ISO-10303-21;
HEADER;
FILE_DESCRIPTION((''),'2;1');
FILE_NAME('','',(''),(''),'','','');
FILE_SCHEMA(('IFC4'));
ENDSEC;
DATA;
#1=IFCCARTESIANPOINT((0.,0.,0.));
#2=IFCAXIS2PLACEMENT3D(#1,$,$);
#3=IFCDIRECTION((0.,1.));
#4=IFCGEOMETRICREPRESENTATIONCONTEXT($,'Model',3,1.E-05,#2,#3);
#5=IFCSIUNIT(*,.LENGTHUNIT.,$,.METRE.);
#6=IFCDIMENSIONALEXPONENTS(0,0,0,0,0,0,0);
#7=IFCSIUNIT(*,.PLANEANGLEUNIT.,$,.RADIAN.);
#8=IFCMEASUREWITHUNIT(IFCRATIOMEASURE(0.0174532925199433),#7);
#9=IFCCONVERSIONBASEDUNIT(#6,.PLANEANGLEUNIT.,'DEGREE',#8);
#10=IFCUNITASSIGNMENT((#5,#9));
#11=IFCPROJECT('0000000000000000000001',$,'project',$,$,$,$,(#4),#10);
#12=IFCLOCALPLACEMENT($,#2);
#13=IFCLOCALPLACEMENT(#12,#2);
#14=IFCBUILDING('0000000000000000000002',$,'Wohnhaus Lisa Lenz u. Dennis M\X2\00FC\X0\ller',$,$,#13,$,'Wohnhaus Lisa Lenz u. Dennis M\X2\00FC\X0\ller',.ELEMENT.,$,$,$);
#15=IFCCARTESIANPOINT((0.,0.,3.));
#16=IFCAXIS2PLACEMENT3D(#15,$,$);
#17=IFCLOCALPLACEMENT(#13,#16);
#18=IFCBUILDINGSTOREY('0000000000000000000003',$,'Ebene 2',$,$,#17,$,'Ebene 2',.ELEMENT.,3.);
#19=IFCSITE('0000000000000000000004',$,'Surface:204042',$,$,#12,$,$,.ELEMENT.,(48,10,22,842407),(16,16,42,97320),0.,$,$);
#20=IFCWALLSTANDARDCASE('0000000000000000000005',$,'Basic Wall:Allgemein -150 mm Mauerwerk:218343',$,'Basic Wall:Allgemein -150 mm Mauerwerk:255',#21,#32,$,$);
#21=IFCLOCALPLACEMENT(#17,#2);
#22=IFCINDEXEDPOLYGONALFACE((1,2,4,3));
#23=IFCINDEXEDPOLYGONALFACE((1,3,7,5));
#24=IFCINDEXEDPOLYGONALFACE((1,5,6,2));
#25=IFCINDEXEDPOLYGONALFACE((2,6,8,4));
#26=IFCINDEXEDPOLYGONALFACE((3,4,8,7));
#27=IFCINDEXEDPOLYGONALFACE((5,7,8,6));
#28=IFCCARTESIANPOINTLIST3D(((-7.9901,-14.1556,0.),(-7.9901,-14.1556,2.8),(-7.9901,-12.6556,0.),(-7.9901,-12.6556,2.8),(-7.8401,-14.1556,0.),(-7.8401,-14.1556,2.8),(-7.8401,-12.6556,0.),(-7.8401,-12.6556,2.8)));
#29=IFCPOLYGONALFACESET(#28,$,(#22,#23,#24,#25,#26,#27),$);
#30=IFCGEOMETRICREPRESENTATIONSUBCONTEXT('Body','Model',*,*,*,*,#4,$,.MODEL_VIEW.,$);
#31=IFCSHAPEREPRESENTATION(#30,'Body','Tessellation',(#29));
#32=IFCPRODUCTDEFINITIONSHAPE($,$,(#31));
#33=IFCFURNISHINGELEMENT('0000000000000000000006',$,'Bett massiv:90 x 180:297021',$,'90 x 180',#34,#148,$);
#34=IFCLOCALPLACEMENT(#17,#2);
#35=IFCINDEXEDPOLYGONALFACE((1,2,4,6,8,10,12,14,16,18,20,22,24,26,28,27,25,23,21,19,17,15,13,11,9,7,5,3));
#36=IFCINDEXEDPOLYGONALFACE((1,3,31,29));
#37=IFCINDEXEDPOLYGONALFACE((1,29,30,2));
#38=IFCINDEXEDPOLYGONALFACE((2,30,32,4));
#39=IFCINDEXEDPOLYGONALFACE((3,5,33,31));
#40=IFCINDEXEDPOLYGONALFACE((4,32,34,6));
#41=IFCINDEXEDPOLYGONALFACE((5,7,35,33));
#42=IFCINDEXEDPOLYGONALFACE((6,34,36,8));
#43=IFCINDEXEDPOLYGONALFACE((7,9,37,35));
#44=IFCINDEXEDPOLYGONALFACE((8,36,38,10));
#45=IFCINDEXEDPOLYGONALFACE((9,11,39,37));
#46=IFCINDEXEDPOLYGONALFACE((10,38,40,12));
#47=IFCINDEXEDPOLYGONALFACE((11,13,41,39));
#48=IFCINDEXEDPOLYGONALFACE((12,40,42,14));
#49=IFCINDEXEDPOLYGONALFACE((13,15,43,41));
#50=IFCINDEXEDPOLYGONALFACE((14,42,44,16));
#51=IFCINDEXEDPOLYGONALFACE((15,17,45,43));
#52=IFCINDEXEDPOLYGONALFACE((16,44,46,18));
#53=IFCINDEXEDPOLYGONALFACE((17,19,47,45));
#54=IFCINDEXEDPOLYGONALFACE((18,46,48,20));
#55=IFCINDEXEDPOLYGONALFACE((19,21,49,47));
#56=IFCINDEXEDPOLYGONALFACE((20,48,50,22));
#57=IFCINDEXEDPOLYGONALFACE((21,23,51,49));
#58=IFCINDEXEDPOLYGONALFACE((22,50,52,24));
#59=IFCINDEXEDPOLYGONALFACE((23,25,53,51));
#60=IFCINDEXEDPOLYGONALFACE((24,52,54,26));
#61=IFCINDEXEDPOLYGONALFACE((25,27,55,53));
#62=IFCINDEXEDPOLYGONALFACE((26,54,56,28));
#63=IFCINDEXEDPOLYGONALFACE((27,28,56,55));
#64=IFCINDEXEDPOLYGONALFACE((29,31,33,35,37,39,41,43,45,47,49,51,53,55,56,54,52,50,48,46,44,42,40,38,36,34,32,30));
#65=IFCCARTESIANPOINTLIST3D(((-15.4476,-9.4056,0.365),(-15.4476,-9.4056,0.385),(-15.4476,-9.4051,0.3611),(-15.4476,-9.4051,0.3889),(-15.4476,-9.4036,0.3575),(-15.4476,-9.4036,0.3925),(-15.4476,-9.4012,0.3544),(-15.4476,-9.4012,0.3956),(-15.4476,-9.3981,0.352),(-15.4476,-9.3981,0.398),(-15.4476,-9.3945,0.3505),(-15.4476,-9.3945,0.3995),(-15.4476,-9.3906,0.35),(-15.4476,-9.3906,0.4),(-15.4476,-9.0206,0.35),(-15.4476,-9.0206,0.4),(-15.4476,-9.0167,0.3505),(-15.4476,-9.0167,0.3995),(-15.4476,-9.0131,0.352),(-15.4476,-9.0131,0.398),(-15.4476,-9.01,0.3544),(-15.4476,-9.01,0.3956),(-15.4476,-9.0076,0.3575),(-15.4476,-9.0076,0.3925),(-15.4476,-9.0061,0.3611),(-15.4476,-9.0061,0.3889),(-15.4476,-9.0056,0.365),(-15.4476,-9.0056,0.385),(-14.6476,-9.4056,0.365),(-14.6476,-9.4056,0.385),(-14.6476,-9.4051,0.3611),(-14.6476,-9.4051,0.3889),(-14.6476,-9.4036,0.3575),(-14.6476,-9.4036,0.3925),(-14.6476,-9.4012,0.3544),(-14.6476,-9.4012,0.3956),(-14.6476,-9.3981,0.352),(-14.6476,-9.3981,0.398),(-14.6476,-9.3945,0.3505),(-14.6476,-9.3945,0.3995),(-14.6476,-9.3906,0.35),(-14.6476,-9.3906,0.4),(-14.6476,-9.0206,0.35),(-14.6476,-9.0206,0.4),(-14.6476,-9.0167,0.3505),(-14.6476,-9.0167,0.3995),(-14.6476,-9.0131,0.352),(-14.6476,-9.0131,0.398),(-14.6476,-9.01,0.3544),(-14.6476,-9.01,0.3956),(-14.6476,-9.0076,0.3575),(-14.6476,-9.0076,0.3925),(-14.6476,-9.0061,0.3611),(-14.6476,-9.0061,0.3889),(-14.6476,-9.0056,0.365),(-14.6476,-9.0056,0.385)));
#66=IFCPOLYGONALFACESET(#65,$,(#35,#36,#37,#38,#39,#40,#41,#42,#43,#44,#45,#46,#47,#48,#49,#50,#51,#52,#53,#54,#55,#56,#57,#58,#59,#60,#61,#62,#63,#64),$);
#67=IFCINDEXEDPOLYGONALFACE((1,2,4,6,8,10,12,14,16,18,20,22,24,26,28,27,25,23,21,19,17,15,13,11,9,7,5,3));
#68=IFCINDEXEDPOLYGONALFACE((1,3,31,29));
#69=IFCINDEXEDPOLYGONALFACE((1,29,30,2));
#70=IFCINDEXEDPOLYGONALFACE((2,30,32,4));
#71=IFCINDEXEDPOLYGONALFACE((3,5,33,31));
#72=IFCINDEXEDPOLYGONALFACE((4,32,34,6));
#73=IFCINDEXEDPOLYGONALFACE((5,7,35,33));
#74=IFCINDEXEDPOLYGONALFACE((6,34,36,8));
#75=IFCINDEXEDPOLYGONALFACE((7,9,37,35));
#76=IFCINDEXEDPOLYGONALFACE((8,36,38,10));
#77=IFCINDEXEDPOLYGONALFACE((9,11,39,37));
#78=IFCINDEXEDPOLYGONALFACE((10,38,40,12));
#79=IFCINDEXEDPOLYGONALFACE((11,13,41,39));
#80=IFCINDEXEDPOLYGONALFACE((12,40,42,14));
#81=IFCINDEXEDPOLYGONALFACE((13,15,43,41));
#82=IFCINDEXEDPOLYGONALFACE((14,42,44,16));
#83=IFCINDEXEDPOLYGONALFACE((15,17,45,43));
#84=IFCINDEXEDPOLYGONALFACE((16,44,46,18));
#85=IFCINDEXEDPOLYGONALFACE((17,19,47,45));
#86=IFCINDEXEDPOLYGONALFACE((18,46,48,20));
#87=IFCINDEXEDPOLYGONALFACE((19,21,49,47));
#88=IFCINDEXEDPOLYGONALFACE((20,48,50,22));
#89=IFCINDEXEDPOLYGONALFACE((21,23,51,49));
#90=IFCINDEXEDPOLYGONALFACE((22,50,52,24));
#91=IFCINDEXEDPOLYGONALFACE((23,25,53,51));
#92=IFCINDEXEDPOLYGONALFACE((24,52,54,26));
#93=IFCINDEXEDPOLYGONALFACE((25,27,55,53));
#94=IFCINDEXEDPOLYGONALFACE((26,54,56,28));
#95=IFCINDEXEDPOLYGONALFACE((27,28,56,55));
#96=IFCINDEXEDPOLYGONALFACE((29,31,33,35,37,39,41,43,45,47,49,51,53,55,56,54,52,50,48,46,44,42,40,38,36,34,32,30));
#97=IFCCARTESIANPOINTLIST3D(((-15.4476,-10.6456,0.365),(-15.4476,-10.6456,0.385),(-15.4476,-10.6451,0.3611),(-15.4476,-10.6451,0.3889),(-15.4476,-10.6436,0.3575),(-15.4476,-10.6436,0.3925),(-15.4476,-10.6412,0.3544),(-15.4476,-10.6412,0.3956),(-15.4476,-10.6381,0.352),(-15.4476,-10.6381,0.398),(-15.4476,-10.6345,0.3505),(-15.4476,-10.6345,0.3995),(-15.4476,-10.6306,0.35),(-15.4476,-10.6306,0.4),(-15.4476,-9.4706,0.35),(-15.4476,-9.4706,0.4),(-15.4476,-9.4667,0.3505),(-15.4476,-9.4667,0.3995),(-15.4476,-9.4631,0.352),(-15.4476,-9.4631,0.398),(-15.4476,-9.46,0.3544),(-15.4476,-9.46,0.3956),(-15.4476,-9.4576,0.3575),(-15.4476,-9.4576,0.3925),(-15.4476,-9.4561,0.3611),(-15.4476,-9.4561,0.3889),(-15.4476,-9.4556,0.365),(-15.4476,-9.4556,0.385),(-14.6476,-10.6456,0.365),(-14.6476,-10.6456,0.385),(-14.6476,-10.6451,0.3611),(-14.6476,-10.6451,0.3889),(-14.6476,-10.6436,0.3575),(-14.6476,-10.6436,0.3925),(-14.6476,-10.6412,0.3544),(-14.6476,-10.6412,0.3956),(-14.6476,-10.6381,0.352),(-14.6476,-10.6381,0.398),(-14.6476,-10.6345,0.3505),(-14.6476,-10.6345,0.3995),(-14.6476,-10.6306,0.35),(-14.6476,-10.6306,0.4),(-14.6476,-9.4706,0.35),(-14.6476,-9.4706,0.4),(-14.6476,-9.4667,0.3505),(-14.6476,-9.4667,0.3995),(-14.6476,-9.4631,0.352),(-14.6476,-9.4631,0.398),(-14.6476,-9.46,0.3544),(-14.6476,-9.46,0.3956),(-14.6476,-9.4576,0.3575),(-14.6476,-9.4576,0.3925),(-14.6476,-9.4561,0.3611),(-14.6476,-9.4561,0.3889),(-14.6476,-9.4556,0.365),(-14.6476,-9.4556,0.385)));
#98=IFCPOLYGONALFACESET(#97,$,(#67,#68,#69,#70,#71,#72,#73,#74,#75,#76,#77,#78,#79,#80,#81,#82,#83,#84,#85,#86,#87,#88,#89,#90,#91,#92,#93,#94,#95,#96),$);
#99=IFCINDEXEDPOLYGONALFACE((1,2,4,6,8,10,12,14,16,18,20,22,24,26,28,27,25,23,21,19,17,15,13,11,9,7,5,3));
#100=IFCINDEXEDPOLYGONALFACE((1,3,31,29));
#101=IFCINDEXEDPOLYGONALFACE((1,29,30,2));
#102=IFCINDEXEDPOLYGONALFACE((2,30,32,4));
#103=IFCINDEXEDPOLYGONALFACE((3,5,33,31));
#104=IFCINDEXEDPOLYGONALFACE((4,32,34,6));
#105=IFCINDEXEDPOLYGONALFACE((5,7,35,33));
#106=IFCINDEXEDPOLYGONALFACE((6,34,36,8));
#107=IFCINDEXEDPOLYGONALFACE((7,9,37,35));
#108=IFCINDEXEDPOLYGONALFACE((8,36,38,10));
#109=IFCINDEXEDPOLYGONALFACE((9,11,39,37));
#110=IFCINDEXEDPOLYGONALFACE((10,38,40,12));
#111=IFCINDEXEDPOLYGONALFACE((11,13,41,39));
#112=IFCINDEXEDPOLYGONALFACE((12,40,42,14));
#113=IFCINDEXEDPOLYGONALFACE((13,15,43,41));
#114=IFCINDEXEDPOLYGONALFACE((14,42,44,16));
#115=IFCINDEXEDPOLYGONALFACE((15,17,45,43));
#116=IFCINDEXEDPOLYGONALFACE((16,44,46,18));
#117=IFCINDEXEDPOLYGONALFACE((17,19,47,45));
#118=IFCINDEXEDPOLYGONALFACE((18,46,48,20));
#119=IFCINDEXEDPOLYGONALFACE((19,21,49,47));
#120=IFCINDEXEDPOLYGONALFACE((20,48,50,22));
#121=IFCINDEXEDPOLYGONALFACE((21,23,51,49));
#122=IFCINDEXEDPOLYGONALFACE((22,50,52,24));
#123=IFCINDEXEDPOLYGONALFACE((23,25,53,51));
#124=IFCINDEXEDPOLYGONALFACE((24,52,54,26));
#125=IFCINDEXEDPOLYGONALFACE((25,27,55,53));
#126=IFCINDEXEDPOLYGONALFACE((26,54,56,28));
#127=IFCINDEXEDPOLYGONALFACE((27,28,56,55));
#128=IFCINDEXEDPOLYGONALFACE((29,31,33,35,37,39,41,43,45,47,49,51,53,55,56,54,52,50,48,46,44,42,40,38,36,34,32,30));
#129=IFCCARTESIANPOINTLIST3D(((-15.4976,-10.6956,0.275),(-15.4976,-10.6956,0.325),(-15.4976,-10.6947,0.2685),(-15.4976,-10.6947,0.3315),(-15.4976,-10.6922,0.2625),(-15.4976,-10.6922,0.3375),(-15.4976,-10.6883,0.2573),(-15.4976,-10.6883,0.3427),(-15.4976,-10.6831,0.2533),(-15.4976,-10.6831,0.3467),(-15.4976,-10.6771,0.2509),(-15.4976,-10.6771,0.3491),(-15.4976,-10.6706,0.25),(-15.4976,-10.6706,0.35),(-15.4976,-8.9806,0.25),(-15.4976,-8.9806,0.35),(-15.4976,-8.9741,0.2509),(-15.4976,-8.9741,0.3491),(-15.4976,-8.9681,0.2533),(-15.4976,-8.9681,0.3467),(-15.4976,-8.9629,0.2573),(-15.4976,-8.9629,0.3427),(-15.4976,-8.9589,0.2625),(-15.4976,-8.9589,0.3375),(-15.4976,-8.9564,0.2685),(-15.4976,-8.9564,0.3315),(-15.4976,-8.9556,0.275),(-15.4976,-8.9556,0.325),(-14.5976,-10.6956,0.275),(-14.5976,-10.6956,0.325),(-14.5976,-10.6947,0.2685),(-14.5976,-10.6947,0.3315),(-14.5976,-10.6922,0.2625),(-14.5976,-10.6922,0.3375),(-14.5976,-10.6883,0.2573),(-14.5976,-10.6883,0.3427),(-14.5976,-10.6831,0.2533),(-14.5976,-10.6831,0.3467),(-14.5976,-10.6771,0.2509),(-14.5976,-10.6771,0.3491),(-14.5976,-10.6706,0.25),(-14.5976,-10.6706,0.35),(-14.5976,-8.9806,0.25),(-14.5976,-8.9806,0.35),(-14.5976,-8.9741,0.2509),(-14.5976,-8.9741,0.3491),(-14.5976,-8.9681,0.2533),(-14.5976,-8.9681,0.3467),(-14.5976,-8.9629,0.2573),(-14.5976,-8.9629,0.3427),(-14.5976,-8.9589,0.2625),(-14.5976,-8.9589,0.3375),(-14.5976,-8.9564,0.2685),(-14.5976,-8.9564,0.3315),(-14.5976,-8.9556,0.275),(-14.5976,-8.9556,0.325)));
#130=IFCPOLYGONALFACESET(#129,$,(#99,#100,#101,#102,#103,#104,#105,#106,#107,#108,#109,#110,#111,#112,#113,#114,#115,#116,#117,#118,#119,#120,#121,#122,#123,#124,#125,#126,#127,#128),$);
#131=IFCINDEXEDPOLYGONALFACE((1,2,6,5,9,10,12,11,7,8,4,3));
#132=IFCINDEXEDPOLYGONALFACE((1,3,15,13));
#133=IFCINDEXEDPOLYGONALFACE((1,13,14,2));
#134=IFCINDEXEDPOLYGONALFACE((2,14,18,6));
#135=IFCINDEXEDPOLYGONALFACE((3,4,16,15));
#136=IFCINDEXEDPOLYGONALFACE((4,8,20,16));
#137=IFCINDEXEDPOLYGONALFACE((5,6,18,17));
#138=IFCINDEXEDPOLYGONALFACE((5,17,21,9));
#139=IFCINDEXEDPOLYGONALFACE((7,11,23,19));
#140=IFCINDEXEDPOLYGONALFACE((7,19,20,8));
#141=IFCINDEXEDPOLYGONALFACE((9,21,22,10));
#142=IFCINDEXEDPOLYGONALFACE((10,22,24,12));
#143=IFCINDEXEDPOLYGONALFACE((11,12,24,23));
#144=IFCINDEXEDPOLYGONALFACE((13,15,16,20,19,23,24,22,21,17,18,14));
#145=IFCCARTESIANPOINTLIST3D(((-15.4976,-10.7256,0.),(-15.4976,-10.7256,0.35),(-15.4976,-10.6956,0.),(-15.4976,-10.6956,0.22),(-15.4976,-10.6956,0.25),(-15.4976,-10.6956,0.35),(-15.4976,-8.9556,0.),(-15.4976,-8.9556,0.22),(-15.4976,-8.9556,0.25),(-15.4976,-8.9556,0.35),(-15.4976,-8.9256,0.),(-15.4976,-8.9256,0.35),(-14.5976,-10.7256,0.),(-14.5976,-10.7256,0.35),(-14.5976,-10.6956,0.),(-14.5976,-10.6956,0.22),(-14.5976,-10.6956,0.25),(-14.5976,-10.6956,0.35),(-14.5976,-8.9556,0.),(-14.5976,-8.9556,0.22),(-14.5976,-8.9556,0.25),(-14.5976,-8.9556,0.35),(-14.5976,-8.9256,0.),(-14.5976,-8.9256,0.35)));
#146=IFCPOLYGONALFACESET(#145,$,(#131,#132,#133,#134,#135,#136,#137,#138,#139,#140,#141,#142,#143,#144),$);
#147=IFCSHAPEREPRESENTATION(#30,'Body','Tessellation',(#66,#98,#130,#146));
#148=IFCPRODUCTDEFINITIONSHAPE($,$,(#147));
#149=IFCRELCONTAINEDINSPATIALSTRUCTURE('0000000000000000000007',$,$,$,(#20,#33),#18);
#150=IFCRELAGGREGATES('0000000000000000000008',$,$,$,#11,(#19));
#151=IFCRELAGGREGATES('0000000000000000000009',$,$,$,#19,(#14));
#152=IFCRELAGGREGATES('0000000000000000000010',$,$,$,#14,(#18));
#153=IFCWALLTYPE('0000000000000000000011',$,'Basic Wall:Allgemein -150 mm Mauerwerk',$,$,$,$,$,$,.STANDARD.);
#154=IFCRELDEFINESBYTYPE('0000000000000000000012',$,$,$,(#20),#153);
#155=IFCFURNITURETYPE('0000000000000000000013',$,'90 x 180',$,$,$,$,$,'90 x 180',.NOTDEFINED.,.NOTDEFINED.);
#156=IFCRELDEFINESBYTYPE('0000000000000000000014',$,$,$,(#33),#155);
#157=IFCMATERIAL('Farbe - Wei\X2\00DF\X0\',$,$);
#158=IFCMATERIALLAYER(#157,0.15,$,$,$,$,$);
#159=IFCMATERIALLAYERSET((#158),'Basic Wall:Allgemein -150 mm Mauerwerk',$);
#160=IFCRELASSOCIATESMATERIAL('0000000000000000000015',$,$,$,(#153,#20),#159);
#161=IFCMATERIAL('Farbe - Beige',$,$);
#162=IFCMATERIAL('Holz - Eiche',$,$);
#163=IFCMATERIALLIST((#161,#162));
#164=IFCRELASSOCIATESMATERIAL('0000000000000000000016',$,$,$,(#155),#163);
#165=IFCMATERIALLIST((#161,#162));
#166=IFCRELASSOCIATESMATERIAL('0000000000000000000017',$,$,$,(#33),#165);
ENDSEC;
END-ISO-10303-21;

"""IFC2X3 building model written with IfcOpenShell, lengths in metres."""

from ifc_helpers import new_model, entity, si_unit, converted_unit, direction, frame, frame_2d, origin, place, context, subcontext, project, spatial, polyline, circle_curve, parameter, trimmed, segment, composite_curve, rectangle, outline, extrude, clip, bounded_halfspace, source, transform, mapped, material, material_list, layer, layer_set, layer_usage, type_object, type_shapes, element, save


model = new_model("IFC2X3")

# Units and contexts
model_context = context("Model", 3, precision=1e-05, world=origin(), true_north=direction((0.0, 1.0)))
body_context = subcontext(model_context, "Body", "Model", "MODEL_VIEW")
ifc_project = project(units=[si_unit("LENGTHUNIT", "METRE"), converted_unit("PLANEANGLEUNIT", "DEGREE", entity("IfcRatioMeasure", 0.0174532925199433), si_unit("PLANEANGLEUNIT", "RADIAN"), dimensions=[0, 0, 0, 0, 0, 0, 0])], contexts=[model_context])

# Site, building, storey
site_placement = place(None, origin())
site = spatial("IfcSite", under=ifc_project, at=site_placement, Name="Surface:204042", CompositionType="ELEMENT", RefLatitude=(48, 10, 22, 842407), RefLongitude=(16, 16, 42, 97320), RefElevation=0.0)
building_placement = place(site_placement, origin())
building = spatial("IfcBuilding", under=site, at=building_placement, Name="Wohnhaus Lisa Lenz u. Dennis Müller", LongName="Wohnhaus Lisa Lenz u. Dennis Müller", CompositionType="ELEMENT")
storey_placement = place(building_placement, frame((0.0, 0.0, 3.0)))
storey = spatial("IfcBuildingStorey", under=building, at=storey_placement, Name="Ebene 2", LongName="Ebene 2", CompositionType="ELEMENT", Elevation=3.0)

# Shared definitions
ifc_material_1 = material(Name="Farbe - Weiß")
ifc_layer_1 = layer(ifc_material_1, 0.15)
ifc_layer_set_1 = layer_set([ifc_layer_1], Name="Basic Wall:Allgemein -150 mm Mauerwerk")
wall_type_1 = type_object("IfcWallType", Name="Basic Wall:Allgemein -150 mm Mauerwerk", PredefinedType="STANDARD", material=ifc_layer_set_1)

# Wall
ifc_layer_usage_1 = layer_usage(ifc_layer_set_1, "AXIS2", "NEGATIVE", 0.075)
wall_1_placement = place(storey_placement, frame((-7.9151, -12.6556, 0.0), z_axis=(0.0, 0.0, 1.0), x_axis=(0.0, -1.0, 0.0)))
element("IfcWallStandardCase", 1, at=wall_1_placement, inside=storey, type_object=wall_type_1, material=ifc_layer_usage_1, Name="Basic Wall:Allgemein -150 mm Mauerwerk:218343", ObjectType="Basic Wall:Allgemein -150 mm Mauerwerk:255", context=body_context, shape_type="Clipping", body=[
    clip(extrude(rectangle(XDim=1.5, YDim=0.15, at=frame_2d((0.75, 0.0), x_axis=(-1.0, 0.0))), origin(), (0.0, 0.0, 1.0), 2.8), bounded_halfspace(frame((0.0, -0.075, 2.8), z_axis=(0.0, 0.0, -1.0), x_axis=(1.0, 0.0, 0.0)), True, frame((0.0, -0.075, 2.8)), polyline([(0.0, 0.0), (1.5, 0.0), (1.5, 0.15), (0.0, 0.15), (0.0, 0.0)]))),
])

# Furnishing element
ifc_material_2 = material(Name="Farbe - Beige")
ifc_material_3 = material(Name="Holz - Eiche")
ifc_material_list_1 = material_list([ifc_material_2, ifc_material_3])
ifc_material_list_2 = material_list([ifc_material_2, ifc_material_3])
furniture_type_1 = type_object("IfcFurnitureType", Name="90 x 180", ElementType="90 x 180", material=ifc_material_list_2)
shared_shape_1 = source(origin(), body_context, "Body", "SweptSolid", [
    extrude(outline(composite_curve([segment(trimmed(circle_curve(frame_2d((-0.185, 0.01), x_axis=(1.0, 0.0)), 0.015), [parameter(90.0)], [parameter(180.0)], True, "PARAMETER"), True, "CONTINUOUS"), segment(polyline([(-0.2, 0.01), (-0.2, -0.01)]), True, "CONTINUOUS"), segment(trimmed(circle_curve(frame_2d((-0.185, -0.01), x_axis=(1.0, 0.0)), 0.015), [parameter(180.0)], [parameter(270.0)], True, "PARAMETER"), True, "CONTINUOUS"), segment(polyline([(-0.185, -0.025), (0.185, -0.025)]), True, "CONTINUOUS"), segment(trimmed(circle_curve(frame_2d((0.185, -0.01), x_axis=(1.0, 0.0)), 0.015), [parameter(270.0)], [parameter(0.0)], True, "PARAMETER"), True, "CONTINUOUS"), segment(polyline([(0.2, -0.01), (0.2, 0.01)]), True, "CONTINUOUS"), segment(trimmed(circle_curve(frame_2d((0.185, 0.01), x_axis=(1.0, 0.0)), 0.015), [parameter(0.0)], [parameter(90.0)], True, "PARAMETER"), True, "CONTINUOUS"), segment(polyline([(0.185, 0.025), (-0.185, 0.025)]), True, "CONTINUOUS")], self_intersect=False)), frame((-0.4, 0.62, 0.375), z_axis=(1.0, 0.0, 0.0), x_axis=(0.0, 1.0, 0.0)), (0.0, 0.0, 1.0), 0.8),
    extrude(outline(composite_curve([segment(trimmed(circle_curve(frame_2d((0.58, -0.01), x_axis=(1.0, 0.0)), 0.015), [parameter(270.0)], [parameter(0.0)], True, "PARAMETER"), True, "CONTINUOUS"), segment(polyline([(0.595, -0.01), (0.595, 0.01)]), True, "CONTINUOUS"), segment(trimmed(circle_curve(frame_2d((0.58, 0.01), x_axis=(1.0, 0.0)), 0.015), [parameter(0.0)], [parameter(90.0)], True, "PARAMETER"), True, "CONTINUOUS"), segment(polyline([(0.58, 0.025), (-0.58, 0.025)]), True, "CONTINUOUS"), segment(trimmed(circle_curve(frame_2d((-0.58, 0.01), x_axis=(1.0, 0.0)), 0.015), [parameter(90.0)], [parameter(180.0)], True, "PARAMETER"), True, "CONTINUOUS"), segment(polyline([(-0.595, 0.01), (-0.595, -0.01)]), True, "CONTINUOUS"), segment(trimmed(circle_curve(frame_2d((-0.58, -0.01), x_axis=(1.0, 0.0)), 0.015), [parameter(180.0)], [parameter(270.0)], True, "PARAMETER"), True, "CONTINUOUS"), segment(polyline([(-0.58, -0.025), (0.58, -0.025)]), True, "CONTINUOUS")], self_intersect=False)), frame((-0.4, -0.225, 0.375), z_axis=(1.0, 0.0, 0.0), x_axis=(0.0, 1.0, 0.0)), (0.0, 0.0, 1.0), 0.8),
    extrude(outline(composite_curve([segment(polyline([(-0.845, -0.05), (0.845, -0.05)]), True, "CONTINUOUS"), segment(trimmed(circle_curve(frame_2d((0.845, -0.025), x_axis=(-1.0, 0.0)), 0.025), [parameter(90.0)], [parameter(180.0)], True, "PARAMETER"), True, "CONTINUOUS"), segment(polyline([(0.87, -0.025), (0.87, 0.025)]), True, "CONTINUOUS"), segment(trimmed(circle_curve(frame_2d((0.845, 0.025), x_axis=(-1.0, 0.0)), 0.025), [parameter(180.0)], [parameter(270.0)], True, "PARAMETER"), True, "CONTINUOUS"), segment(polyline([(0.845, 0.05), (-0.845, 0.05)]), True, "CONTINUOUS"), segment(trimmed(circle_curve(frame_2d((-0.845, 0.025), x_axis=(-1.0, 0.0)), 0.025), [parameter(270.0)], [parameter(0.0)], True, "PARAMETER"), True, "CONTINUOUS"), segment(polyline([(-0.87, 0.025), (-0.87, -0.025)]), True, "CONTINUOUS"), segment(trimmed(circle_curve(frame_2d((-0.845, -0.025), x_axis=(-1.0, 0.0)), 0.025), [parameter(360.0)], [parameter(90.0)], True, "PARAMETER"), True, "CONTINUOUS")], self_intersect=False)), frame((-0.45, 0.0, 0.3), z_axis=(1.0, 0.0, 0.0), x_axis=(0.0, -1.0, 0.0)), (0.0, 0.0, 1.0), 0.9),
    extrude(outline(polyline([(-0.87, 0.055), (-0.87, 0.155), (-0.9, 0.155), (-0.9, -0.195), (-0.87, -0.195), (-0.87, 0.025), (0.87, 0.025), (0.87, -0.195), (0.9, -0.195), (0.9, 0.155), (0.87, 0.155), (0.87, 0.055), (-0.87, 0.055)])), frame((-0.45, 0.0, 0.195), z_axis=(-1.0, 0.0, 0.0), x_axis=(0.0, -1.0, 0.0)), (0.0, 0.0, -1.0), 0.9),
])
type_shapes(furniture_type_1, [shared_shape_1])
furnishing_1_placement = place(storey_placement, frame((-15.0476, -9.8256, 0.0)))
element("IfcFurnishingElement", 2, at=furnishing_1_placement, inside=storey, type_object=furniture_type_1, material=ifc_material_list_1, Name="Bett massiv:90 x 180:297021", ObjectType="90 x 180", context=body_context, shape_type="MappedRepresentation", body=[
    mapped(shared_shape_1, transform((0.0, 0.0, 0.0), scale=1.0)),
])

save(model, "model.ifc")
